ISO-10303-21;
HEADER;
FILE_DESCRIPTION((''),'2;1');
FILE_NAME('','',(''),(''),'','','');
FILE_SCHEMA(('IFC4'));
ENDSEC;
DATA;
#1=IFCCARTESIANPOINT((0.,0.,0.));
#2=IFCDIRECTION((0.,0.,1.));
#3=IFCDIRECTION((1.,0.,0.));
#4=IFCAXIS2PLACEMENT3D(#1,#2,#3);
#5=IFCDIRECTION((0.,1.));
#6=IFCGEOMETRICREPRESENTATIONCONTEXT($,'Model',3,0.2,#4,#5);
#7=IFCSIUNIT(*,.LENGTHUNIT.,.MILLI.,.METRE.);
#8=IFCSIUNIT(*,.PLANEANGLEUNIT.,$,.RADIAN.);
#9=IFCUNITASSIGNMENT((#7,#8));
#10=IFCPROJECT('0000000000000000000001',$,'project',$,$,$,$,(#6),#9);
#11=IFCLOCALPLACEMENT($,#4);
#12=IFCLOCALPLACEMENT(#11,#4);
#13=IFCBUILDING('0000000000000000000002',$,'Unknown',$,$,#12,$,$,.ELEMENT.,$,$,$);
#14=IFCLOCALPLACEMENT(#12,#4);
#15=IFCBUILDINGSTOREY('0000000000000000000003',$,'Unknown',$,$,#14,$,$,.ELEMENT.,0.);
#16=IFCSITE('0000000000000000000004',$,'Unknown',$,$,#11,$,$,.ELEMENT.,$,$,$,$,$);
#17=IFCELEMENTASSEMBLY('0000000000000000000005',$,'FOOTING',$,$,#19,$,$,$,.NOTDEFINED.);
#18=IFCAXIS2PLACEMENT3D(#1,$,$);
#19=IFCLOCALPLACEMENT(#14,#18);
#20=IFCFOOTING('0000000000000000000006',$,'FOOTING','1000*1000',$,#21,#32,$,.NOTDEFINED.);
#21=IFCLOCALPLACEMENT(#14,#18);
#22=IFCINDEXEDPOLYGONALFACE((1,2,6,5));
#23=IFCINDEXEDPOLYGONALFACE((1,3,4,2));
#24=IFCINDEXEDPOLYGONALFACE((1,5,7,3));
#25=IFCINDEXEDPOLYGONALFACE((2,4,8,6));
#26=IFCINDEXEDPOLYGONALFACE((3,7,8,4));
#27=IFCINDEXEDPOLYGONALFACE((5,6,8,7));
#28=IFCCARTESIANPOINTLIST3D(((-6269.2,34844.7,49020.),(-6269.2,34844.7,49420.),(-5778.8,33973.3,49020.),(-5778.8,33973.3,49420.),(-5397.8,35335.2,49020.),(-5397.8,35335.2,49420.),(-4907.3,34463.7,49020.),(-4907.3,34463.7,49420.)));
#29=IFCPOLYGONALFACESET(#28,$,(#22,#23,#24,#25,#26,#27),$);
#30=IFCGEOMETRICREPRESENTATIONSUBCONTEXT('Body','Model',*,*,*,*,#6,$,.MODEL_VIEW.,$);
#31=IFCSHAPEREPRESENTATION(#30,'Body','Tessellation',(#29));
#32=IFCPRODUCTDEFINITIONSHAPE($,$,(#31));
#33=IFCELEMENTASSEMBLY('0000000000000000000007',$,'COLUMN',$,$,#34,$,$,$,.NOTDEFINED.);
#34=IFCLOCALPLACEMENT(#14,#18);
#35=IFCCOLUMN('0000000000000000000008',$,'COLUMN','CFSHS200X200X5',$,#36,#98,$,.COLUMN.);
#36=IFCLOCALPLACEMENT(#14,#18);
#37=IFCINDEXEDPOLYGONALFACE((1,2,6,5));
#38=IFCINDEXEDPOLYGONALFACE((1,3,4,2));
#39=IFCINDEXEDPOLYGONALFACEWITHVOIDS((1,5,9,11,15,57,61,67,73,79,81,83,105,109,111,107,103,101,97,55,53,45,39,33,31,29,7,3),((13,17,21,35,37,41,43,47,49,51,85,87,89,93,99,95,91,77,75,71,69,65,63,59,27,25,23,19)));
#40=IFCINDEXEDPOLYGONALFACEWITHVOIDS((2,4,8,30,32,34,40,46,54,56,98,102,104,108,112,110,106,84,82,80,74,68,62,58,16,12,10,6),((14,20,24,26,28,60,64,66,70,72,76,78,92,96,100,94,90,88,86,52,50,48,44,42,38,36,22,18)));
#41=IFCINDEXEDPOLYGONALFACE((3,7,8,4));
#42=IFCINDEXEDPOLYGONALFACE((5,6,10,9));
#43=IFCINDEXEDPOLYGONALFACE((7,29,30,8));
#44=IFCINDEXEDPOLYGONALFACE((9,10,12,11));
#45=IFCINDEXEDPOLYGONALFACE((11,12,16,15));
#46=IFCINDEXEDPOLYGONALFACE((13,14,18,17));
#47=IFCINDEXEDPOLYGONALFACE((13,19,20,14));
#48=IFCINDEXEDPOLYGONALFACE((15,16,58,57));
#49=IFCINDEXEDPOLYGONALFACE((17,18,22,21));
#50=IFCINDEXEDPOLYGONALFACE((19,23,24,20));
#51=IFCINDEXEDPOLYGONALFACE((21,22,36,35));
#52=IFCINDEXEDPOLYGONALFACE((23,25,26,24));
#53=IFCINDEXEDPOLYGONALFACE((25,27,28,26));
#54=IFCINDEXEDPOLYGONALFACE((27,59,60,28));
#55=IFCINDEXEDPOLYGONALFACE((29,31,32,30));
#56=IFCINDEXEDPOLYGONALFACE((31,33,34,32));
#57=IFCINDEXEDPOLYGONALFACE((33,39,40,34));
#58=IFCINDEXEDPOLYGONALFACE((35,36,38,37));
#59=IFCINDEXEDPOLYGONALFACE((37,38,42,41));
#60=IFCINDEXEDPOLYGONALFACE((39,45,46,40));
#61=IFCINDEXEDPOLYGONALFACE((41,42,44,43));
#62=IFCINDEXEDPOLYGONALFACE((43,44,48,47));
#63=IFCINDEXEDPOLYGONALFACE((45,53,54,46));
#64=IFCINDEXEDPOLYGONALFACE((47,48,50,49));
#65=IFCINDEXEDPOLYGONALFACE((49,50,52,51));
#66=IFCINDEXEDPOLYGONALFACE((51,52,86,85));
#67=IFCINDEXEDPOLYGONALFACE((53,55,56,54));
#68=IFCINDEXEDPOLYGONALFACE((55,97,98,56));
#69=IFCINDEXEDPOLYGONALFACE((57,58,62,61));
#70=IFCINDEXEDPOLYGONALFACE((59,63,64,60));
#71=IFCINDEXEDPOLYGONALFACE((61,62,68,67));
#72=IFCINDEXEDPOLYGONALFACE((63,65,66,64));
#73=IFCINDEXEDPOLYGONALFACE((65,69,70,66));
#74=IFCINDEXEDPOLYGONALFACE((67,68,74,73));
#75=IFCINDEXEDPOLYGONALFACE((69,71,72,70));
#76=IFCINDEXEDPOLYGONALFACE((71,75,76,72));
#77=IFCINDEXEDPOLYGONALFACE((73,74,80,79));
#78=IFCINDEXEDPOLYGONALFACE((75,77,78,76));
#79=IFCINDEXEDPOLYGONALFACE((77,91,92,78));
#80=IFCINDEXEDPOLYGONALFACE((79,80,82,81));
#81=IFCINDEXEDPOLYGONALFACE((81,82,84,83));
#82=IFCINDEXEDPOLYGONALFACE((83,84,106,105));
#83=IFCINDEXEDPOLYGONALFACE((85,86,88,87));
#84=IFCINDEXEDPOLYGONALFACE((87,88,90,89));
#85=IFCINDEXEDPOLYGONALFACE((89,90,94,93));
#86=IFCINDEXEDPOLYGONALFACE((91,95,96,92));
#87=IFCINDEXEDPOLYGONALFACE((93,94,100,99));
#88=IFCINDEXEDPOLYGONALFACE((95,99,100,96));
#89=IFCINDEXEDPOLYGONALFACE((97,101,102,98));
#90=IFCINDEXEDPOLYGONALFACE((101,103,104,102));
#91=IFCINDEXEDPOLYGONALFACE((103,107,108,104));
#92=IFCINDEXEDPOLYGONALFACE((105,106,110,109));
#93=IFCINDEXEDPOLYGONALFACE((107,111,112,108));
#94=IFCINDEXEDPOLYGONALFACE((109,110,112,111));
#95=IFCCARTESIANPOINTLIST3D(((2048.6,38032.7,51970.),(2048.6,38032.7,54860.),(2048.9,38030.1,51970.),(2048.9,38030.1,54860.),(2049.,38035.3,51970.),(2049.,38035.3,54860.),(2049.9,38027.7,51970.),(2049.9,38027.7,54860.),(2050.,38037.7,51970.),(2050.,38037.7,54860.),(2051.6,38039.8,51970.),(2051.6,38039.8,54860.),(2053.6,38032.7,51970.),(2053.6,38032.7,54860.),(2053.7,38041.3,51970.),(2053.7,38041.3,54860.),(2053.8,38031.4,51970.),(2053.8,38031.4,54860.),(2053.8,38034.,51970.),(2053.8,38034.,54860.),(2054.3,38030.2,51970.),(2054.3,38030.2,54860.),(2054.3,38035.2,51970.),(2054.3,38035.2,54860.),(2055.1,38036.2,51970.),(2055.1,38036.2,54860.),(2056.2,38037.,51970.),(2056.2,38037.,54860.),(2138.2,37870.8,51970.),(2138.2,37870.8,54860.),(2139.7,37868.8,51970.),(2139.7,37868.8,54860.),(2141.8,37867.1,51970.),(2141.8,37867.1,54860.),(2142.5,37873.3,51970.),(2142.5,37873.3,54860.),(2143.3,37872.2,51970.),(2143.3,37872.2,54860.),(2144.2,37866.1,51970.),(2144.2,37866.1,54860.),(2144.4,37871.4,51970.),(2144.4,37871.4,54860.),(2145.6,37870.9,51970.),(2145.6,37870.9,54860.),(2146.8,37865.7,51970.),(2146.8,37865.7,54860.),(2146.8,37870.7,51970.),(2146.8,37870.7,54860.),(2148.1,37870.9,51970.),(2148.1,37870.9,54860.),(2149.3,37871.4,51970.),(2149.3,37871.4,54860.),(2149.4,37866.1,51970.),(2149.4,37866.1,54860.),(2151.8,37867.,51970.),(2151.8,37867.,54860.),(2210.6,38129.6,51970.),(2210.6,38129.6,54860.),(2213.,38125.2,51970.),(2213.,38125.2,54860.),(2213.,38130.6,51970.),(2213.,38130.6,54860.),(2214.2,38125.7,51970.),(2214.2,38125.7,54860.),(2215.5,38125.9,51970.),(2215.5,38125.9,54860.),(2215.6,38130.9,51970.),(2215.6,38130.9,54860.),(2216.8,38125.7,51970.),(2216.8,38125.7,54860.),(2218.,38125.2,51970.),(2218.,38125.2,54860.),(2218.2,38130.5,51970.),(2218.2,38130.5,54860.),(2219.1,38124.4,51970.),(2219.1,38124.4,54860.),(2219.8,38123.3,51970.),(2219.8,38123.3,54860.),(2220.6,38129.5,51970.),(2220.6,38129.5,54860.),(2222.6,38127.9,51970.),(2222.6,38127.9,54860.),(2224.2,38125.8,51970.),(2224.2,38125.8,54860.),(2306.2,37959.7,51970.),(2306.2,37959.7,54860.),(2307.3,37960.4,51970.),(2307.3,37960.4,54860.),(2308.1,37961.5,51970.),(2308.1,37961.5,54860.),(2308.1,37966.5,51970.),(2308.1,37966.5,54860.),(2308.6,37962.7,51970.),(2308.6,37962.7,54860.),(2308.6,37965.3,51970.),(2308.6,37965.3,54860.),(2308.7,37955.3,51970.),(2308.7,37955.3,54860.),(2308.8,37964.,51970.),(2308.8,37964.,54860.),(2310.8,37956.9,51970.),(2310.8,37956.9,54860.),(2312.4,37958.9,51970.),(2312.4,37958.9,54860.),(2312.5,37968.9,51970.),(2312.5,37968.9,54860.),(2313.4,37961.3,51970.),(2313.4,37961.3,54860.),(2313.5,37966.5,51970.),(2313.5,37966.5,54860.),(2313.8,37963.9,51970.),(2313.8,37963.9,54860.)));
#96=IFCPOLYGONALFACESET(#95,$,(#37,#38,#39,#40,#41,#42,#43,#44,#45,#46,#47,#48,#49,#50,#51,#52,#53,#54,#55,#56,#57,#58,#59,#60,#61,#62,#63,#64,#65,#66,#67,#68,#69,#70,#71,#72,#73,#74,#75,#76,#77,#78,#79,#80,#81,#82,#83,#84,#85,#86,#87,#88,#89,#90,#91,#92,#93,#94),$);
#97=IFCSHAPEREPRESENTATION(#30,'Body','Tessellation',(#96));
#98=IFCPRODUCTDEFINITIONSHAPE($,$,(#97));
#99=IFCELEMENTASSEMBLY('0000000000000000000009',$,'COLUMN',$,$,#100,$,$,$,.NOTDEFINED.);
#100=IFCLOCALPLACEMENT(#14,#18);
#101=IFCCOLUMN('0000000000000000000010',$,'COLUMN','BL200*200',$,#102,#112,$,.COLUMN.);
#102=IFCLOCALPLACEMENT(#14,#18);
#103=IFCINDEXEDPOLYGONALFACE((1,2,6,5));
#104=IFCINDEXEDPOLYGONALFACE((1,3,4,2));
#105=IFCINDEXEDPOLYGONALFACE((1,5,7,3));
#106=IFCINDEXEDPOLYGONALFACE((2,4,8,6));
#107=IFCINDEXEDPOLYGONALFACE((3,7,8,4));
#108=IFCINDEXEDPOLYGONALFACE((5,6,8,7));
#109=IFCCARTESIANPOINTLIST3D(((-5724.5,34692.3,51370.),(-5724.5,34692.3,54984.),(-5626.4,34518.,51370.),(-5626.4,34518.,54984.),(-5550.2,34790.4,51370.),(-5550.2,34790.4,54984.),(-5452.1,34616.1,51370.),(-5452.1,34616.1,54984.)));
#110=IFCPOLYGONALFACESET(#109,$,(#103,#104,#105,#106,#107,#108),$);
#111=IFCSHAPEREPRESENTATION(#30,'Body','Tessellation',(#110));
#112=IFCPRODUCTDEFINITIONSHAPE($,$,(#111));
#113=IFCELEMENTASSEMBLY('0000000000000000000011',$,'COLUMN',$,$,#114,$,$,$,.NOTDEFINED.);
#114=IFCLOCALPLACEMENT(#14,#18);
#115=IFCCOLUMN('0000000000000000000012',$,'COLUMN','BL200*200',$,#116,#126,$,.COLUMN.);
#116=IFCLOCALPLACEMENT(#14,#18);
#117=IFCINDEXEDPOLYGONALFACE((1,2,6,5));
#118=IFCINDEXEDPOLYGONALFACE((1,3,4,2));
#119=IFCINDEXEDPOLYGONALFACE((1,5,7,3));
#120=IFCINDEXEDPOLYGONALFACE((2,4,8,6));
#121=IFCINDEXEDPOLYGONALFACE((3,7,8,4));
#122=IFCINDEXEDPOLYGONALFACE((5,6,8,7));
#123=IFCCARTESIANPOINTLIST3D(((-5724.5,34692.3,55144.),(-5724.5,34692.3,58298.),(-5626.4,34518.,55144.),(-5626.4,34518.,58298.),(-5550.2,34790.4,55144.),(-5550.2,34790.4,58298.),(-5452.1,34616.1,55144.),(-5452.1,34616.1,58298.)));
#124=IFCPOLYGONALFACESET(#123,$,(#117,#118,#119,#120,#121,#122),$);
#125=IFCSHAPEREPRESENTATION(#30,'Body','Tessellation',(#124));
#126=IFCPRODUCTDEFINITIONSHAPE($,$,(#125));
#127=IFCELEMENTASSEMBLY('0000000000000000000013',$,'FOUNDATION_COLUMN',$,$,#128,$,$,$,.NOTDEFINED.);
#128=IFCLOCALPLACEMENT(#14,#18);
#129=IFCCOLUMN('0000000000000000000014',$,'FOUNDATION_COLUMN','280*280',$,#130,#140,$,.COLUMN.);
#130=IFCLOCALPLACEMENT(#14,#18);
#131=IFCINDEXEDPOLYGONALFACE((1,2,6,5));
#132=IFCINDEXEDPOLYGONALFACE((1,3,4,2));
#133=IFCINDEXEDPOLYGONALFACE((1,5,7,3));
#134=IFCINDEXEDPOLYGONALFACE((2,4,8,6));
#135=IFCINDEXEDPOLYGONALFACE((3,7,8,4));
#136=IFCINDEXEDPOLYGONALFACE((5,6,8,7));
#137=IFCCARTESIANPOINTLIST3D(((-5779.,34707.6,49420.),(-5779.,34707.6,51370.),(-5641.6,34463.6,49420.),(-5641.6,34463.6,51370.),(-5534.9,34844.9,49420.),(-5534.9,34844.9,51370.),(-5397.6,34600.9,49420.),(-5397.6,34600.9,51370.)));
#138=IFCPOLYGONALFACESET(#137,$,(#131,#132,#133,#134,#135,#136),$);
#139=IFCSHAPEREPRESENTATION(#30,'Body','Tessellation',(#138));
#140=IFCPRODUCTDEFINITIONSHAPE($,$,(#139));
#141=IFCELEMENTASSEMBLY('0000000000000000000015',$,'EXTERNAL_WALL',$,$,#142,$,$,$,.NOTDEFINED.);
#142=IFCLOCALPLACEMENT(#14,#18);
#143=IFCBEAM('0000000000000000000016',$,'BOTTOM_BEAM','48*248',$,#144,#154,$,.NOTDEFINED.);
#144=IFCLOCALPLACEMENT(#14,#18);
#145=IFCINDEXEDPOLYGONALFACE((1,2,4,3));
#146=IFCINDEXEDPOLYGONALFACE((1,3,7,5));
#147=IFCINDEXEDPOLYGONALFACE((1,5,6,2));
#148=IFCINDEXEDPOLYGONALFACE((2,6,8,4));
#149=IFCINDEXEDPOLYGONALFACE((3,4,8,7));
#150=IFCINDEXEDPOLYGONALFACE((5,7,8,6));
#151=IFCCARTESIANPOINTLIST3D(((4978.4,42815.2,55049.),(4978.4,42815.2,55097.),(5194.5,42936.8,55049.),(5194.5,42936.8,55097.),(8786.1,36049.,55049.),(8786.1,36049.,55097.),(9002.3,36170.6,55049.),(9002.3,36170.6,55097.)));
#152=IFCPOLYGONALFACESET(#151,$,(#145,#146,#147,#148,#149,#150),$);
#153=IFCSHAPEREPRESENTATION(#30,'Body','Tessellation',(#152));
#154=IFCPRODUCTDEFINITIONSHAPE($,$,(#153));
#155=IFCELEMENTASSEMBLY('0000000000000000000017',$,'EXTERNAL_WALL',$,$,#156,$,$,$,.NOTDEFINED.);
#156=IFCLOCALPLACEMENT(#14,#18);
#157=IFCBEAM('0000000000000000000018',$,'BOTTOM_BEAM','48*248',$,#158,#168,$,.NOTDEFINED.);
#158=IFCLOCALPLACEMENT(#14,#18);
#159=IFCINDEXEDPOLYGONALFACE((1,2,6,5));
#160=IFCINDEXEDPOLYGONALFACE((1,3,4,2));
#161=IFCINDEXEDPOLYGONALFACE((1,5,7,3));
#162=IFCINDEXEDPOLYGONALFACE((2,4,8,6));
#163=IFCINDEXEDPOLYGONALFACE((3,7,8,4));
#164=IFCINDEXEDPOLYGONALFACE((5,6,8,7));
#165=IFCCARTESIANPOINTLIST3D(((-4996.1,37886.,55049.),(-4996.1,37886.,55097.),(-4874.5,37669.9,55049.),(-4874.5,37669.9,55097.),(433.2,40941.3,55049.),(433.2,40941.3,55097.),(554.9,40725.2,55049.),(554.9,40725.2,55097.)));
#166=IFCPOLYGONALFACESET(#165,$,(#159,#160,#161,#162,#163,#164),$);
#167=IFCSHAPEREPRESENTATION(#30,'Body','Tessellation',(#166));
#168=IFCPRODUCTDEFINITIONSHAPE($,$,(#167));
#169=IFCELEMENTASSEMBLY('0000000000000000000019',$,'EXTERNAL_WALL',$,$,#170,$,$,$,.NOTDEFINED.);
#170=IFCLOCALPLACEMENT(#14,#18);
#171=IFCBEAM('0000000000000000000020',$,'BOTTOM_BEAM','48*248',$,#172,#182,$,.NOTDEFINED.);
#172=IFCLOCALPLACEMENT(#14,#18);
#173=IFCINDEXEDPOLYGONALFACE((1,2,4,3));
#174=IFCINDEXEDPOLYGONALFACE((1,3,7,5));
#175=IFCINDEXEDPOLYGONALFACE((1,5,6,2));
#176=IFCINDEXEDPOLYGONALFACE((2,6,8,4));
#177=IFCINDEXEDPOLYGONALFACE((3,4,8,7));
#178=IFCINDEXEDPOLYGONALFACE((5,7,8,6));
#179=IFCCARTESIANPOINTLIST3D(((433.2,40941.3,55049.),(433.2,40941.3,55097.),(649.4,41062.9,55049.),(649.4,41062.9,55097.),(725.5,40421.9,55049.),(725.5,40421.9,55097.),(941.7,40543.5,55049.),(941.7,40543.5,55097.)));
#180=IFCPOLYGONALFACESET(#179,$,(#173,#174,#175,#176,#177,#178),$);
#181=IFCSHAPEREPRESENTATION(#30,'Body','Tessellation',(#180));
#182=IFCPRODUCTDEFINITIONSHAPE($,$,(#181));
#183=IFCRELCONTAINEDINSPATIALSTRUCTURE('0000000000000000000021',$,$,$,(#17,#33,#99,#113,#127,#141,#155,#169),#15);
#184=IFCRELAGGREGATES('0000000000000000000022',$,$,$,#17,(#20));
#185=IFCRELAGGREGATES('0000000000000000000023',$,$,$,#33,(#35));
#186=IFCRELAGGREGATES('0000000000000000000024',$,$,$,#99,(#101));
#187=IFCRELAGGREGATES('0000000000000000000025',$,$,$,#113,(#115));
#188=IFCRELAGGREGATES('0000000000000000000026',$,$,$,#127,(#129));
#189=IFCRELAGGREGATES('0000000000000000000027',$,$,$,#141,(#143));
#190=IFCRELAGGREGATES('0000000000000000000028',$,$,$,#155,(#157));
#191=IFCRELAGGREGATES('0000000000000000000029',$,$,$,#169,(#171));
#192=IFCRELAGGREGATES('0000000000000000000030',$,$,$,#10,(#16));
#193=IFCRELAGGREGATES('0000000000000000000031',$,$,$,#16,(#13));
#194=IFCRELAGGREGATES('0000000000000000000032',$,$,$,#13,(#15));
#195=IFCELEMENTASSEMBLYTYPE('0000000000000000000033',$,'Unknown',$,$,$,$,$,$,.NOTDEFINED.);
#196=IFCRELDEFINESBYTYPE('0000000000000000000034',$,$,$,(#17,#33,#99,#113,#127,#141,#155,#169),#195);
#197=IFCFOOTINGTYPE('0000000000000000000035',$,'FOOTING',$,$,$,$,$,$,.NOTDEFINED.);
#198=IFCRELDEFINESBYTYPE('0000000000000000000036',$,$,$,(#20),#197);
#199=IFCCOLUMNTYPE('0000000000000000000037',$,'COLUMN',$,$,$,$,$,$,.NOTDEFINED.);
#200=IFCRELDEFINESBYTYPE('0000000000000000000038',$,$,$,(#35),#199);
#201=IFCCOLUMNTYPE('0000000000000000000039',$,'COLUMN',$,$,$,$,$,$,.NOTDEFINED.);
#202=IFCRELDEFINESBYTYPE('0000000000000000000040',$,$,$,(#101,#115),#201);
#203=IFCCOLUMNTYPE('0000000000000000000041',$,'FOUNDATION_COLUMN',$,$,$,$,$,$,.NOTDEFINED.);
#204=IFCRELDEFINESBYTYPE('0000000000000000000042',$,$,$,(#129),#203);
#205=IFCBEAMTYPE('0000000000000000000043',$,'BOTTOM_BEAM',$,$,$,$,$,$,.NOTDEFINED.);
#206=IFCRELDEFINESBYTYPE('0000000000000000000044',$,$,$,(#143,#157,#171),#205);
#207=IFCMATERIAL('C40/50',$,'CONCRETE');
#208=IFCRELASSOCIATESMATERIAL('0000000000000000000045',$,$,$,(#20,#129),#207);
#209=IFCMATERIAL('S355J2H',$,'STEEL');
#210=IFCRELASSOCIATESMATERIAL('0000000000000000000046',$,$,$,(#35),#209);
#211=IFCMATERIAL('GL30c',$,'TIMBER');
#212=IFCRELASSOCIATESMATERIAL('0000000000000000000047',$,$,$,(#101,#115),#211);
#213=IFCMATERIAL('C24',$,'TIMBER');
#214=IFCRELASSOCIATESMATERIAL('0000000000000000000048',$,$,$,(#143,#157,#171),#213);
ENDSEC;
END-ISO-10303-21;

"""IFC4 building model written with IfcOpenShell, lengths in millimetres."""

from ifc_helpers import new_model, si_unit, direction, frame, origin_with_axes, origin_2d_with_axis, place, context, subcontext, project, spatial, rectangle, hollow_rectangle, extrude, material, material_profile, profile_set, profile_usage, type_object, element, aggregate, save


model = new_model("IFC4")

# Units and contexts
model_context = context("Model", 3, precision=0.2, world=origin_with_axes(), true_north=direction((0.0, 1.0)))
body_context = subcontext(model_context, "Body", "Model", "MODEL_VIEW")
ifc_project = project(units=[si_unit("LENGTHUNIT", "METRE", prefix="MILLI"), si_unit("PLANEANGLEUNIT", "RADIAN")], contexts=[model_context])

# Site, building, storey
site_placement = place(None, origin_with_axes())
site = spatial("IfcSite", under=ifc_project, at=site_placement, Name="Unknown", CompositionType="ELEMENT")
building_placement = place(site_placement, origin_with_axes())
building = spatial("IfcBuilding", under=site, at=building_placement, Name="Unknown", CompositionType="ELEMENT")
storey_placement = place(building_placement, origin_with_axes())
storey = spatial("IfcBuildingStorey", under=building, at=storey_placement, Name="Unknown", CompositionType="ELEMENT", Elevation=0.0)

# Element assembly, footing
element_assembly_type = type_object("IfcElementAssemblyType", Name="Unknown", PredefinedType="NOTDEFINED")
assembly_1_placement = place(storey_placement, frame((-5588.3, 34654.2, 49020.0), z_axis=(-0.490441, 0.871474, 0.0), x_axis=(0.0, 0.0, 1.0)))
assembly_1 = element("IfcElementAssembly", 1, at=assembly_1_placement, inside=storey, type_object=element_assembly_type, Name="FOOTING", PredefinedType="NOTDEFINED")
ifc_material_1 = material(Name="C40/50", Category="CONCRETE")
ifc_material_profile_1 = material_profile(ifc_material_1, rectangle(XDim=1000.0, YDim=1000.0, at=origin_2d_with_axis()), Name="1000*1000")
ifc_profile_set_1 = profile_set([ifc_material_profile_1])
ifc_profile_usage_1 = profile_usage(ifc_profile_set_1, cardinal=5)
footing_type = type_object("IfcFootingType", Name="FOOTING")
footing_placement = place(assembly_1_placement, origin_with_axes())
footing = element("IfcFooting", 2, at=footing_placement, type_object=footing_type, material=ifc_profile_usage_1, Name="FOOTING", Description="1000*1000", PredefinedType="NOTDEFINED", context=body_context, shape_type="SolidModel", body=[
    extrude(rectangle(XDim=1000.0, YDim=1000.0, at=origin_2d_with_axis()), frame((0.0, 0.0, 0.0), z_axis=(-1.0, 0.0, 0.0), x_axis=(0.0, 0.0, 1.0)), (0.0, 0.0, -1.0), 400.0),
])
aggregate(assembly_1, [footing])

# Element assemblies, columns
assembly_2_placement = place(storey_placement, frame((2181.2, 37998.3, 51970.0), z_axis=(-0.871487, -0.490418, 0.0), x_axis=(0.0, 0.0, 1.0)))
assembly_2 = element("IfcElementAssembly", 3, at=assembly_2_placement, inside=storey, type_object=element_assembly_type, Name="COLUMN", PredefinedType="NOTDEFINED")
ifc_material_2 = material(Name="S355J2H", Category="STEEL")
ifc_material_profile_2 = material_profile(ifc_material_2, hollow_rectangle(XDim=200.0, YDim=200.0, WallThickness=5.0, InnerFilletRadius=5.0, OuterFilletRadius=10.0, at=origin_2d_with_axis()), Name="CFSHS200X200X5")
ifc_profile_set_2 = profile_set([ifc_material_profile_2])
ifc_profile_usage_2 = profile_usage(ifc_profile_set_2, cardinal=5)
column_type_1 = type_object("IfcColumnType", Name="COLUMN")
column_1_placement = place(assembly_2_placement, origin_with_axes())
column_1 = element("IfcColumn", 4, at=column_1_placement, type_object=column_type_1, material=ifc_profile_usage_2, Name="COLUMN", Description="CFSHS200X200X5", PredefinedType="COLUMN", context=body_context, shape_type="SolidModel", body=[
    extrude(hollow_rectangle(XDim=200.0, YDim=200.0, WallThickness=5.0, InnerFilletRadius=5.0, OuterFilletRadius=10.0, at=origin_2d_with_axis()), frame((0.0, 0.0, 0.0), z_axis=(-1.0, 0.0, 0.0), x_axis=(0.0, 0.0, 1.0)), (0.0, 0.0, -1.0), 2890.0),
])
aggregate(assembly_2, [column_1])
assembly_3_placement = place(storey_placement, frame((-5588.3, 34654.2, 51370.0), z_axis=(-0.871487, -0.490418, 0.0), x_axis=(0.0, 0.0, 1.0)))
assembly_3 = element("IfcElementAssembly", 5, at=assembly_3_placement, inside=storey, type_object=element_assembly_type, Name="COLUMN", PredefinedType="NOTDEFINED")
ifc_material_3 = material(Name="GL30c", Category="TIMBER")
ifc_material_profile_3 = material_profile(ifc_material_3, rectangle(XDim=200.0, YDim=200.0, at=origin_2d_with_axis()), Name="BL200*200")
ifc_profile_set_3 = profile_set([ifc_material_profile_3])
ifc_profile_usage_3 = profile_usage(ifc_profile_set_3, cardinal=5)
column_type_2 = type_object("IfcColumnType", Name="COLUMN")
column_2_placement = place(assembly_3_placement, origin_with_axes())
column_2 = element("IfcColumn", 6, at=column_2_placement, type_object=column_type_2, material=ifc_profile_usage_3, Name="COLUMN", Description="BL200*200", PredefinedType="COLUMN", context=body_context, shape_type="SolidModel", body=[
    extrude(rectangle(XDim=200.0, YDim=200.0, at=origin_2d_with_axis()), frame((0.0, 0.0, 0.0), z_axis=(-1.0, 0.0, 0.0), x_axis=(0.0, 0.0, 1.0)), (0.0, 0.0, -1.0), 3614.0),
])
aggregate(assembly_3, [column_2])
assembly_4_placement = place(storey_placement, frame((-5588.3, 34654.2, 55144.0), z_axis=(-0.871487, -0.490418, 0.0), x_axis=(0.0, 0.0, 1.0)))
assembly_4 = element("IfcElementAssembly", 7, at=assembly_4_placement, inside=storey, type_object=element_assembly_type, Name="COLUMN", PredefinedType="NOTDEFINED")
column_3_placement = place(assembly_4_placement, origin_with_axes())
column_3 = element("IfcColumn", 8, at=column_3_placement, type_object=column_type_2, material=ifc_profile_usage_3, Name="COLUMN", Description="BL200*200", PredefinedType="COLUMN", context=body_context, shape_type="SolidModel", body=[
    extrude(rectangle(XDim=200.0, YDim=200.0, at=origin_2d_with_axis()), frame((0.0, 0.0, 0.0), z_axis=(-1.0, 0.0, 0.0), x_axis=(0.0, 0.0, 1.0)), (0.0, 0.0, -1.0), 3154.0),
])
aggregate(assembly_4, [column_3])
assembly_5_placement = place(storey_placement, frame((-5588.3, 34654.2, 49420.0), z_axis=(-0.490441, 0.871474, 0.0), x_axis=(0.0, 0.0, 1.0)))
assembly_5 = element("IfcElementAssembly", 9, at=assembly_5_placement, inside=storey, type_object=element_assembly_type, Name="FOUNDATION_COLUMN", PredefinedType="NOTDEFINED")
ifc_material_profile_4 = material_profile(ifc_material_1, rectangle(XDim=280.0, YDim=280.0, at=origin_2d_with_axis()), Name="280*280")
ifc_profile_set_4 = profile_set([ifc_material_profile_4])
ifc_profile_usage_4 = profile_usage(ifc_profile_set_4, cardinal=5)
column_type_3 = type_object("IfcColumnType", Name="FOUNDATION_COLUMN")
column_4_placement = place(assembly_5_placement, origin_with_axes())
column_4 = element("IfcColumn", 10, at=column_4_placement, type_object=column_type_3, material=ifc_profile_usage_4, Name="FOUNDATION_COLUMN", Description="280*280", PredefinedType="COLUMN", context=body_context, shape_type="SolidModel", body=[
    extrude(rectangle(XDim=280.0, YDim=280.0, at=origin_2d_with_axis()), frame((0.0, 0.0, 0.0), z_axis=(-1.0, 0.0, 0.0), x_axis=(0.0, 0.0, 1.0)), (0.0, 0.0, -1.0), 1950.0),
])
aggregate(assembly_5, [column_4])

# Element assemblies, beams
assembly_6_placement = place(storey_placement, frame((5086.5, 42876.0, 58308.0), z_axis=(-0.871477, -0.490436, 0.0), x_axis=(0.490442, -0.871474, 0.0)))
assembly_6 = element("IfcElementAssembly", 11, at=assembly_6_placement, inside=storey, type_object=element_assembly_type, Name="EXTERNAL_WALL", PredefinedType="NOTDEFINED")
ifc_material_4 = material(Name="C24", Category="TIMBER")
ifc_material_profile_5 = material_profile(ifc_material_4, rectangle(XDim=248.0, YDim=48.0, at=origin_2d_with_axis()), Name="48*248")
ifc_profile_set_5 = profile_set([ifc_material_profile_5])
ifc_profile_usage_5 = profile_usage(ifc_profile_set_5, cardinal=3)
beam_type_1 = type_object("IfcBeamType", Name="BOTTOM_BEAM")
beam_1_placement = place(assembly_6_placement, frame((0.0, -3235.0, 0.0), z_axis=(0.0, 0.0, 1.0), x_axis=(1.0, 0.0, 0.0)))
beam_1 = element("IfcBeam", 12, at=beam_1_placement, type_object=beam_type_1, material=ifc_profile_usage_5, Name="BOTTOM_BEAM", Description="48*248", PredefinedType="NOTDEFINED", context=body_context, shape_type="SolidModel", body=[
    extrude(rectangle(XDim=248.0, YDim=48.0, at=origin_2d_with_axis()), frame((0.0, 0.0, 0.0), z_axis=(-1.0, 0.0, 0.0), x_axis=(0.0, 0.0, 1.0)), (0.0, 0.0, -1.0), 7764.0),
])
aggregate(assembly_6, [beam_1])
assembly_7_placement = place(storey_placement, frame((-4935.3, 37777.9, 58308.0), z_axis=(0.490421, -0.871485, 0.0), x_axis=(0.871484, 0.490423, 0.0)))
assembly_7 = element("IfcElementAssembly", 13, at=assembly_7_placement, inside=storey, type_object=element_assembly_type, Name="EXTERNAL_WALL", PredefinedType="NOTDEFINED")
beam_2_placement = place(assembly_7_placement, frame((0.0, -3235.0, 0.0), z_axis=(0.0, 0.0, 1.0), x_axis=(1.0, 0.0, 0.0)))
beam_2 = element("IfcBeam", 14, at=beam_2_placement, type_object=beam_type_1, material=ifc_profile_usage_5, Name="BOTTOM_BEAM", Description="48*248", PredefinedType="NOTDEFINED", context=body_context, shape_type="SolidModel", body=[
    extrude(rectangle(XDim=248.0, YDim=48.0, at=origin_2d_with_axis()), frame((0.0, 0.0, 0.0), z_axis=(-1.0, 0.0, 0.0), x_axis=(0.0, 0.0, 1.0)), (0.0, 0.0, -1.0), 6230.0),
])
aggregate(assembly_7, [beam_2])
assembly_8_placement = place(storey_placement, frame((541.3, 41002.1, 58308.0), z_axis=(-0.871487, -0.490418, 0.0), x_axis=(0.490421, -0.871485, 0.0)))
assembly_8 = element("IfcElementAssembly", 15, at=assembly_8_placement, inside=storey, type_object=element_assembly_type, Name="EXTERNAL_WALL", PredefinedType="NOTDEFINED")
beam_3_placement = place(assembly_8_placement, frame((0.0, -3235.0, 0.0), z_axis=(0.0, 0.0, 1.0), x_axis=(1.0, 0.0, 0.0)))
beam_3 = element("IfcBeam", 16, at=beam_3_placement, type_object=beam_type_1, material=ifc_profile_usage_5, Name="BOTTOM_BEAM", Description="48*248", PredefinedType="NOTDEFINED", context=body_context, shape_type="SolidModel", body=[
    extrude(rectangle(XDim=248.0, YDim=48.0, at=origin_2d_with_axis()), frame((0.0, 0.0, 0.0), z_axis=(-1.0, 0.0, 0.0), x_axis=(0.0, 0.0, 1.0)), (0.0, 0.0, -1.0), 596.0),
])
aggregate(assembly_8, [beam_3])

save(model, "model.ifc")
